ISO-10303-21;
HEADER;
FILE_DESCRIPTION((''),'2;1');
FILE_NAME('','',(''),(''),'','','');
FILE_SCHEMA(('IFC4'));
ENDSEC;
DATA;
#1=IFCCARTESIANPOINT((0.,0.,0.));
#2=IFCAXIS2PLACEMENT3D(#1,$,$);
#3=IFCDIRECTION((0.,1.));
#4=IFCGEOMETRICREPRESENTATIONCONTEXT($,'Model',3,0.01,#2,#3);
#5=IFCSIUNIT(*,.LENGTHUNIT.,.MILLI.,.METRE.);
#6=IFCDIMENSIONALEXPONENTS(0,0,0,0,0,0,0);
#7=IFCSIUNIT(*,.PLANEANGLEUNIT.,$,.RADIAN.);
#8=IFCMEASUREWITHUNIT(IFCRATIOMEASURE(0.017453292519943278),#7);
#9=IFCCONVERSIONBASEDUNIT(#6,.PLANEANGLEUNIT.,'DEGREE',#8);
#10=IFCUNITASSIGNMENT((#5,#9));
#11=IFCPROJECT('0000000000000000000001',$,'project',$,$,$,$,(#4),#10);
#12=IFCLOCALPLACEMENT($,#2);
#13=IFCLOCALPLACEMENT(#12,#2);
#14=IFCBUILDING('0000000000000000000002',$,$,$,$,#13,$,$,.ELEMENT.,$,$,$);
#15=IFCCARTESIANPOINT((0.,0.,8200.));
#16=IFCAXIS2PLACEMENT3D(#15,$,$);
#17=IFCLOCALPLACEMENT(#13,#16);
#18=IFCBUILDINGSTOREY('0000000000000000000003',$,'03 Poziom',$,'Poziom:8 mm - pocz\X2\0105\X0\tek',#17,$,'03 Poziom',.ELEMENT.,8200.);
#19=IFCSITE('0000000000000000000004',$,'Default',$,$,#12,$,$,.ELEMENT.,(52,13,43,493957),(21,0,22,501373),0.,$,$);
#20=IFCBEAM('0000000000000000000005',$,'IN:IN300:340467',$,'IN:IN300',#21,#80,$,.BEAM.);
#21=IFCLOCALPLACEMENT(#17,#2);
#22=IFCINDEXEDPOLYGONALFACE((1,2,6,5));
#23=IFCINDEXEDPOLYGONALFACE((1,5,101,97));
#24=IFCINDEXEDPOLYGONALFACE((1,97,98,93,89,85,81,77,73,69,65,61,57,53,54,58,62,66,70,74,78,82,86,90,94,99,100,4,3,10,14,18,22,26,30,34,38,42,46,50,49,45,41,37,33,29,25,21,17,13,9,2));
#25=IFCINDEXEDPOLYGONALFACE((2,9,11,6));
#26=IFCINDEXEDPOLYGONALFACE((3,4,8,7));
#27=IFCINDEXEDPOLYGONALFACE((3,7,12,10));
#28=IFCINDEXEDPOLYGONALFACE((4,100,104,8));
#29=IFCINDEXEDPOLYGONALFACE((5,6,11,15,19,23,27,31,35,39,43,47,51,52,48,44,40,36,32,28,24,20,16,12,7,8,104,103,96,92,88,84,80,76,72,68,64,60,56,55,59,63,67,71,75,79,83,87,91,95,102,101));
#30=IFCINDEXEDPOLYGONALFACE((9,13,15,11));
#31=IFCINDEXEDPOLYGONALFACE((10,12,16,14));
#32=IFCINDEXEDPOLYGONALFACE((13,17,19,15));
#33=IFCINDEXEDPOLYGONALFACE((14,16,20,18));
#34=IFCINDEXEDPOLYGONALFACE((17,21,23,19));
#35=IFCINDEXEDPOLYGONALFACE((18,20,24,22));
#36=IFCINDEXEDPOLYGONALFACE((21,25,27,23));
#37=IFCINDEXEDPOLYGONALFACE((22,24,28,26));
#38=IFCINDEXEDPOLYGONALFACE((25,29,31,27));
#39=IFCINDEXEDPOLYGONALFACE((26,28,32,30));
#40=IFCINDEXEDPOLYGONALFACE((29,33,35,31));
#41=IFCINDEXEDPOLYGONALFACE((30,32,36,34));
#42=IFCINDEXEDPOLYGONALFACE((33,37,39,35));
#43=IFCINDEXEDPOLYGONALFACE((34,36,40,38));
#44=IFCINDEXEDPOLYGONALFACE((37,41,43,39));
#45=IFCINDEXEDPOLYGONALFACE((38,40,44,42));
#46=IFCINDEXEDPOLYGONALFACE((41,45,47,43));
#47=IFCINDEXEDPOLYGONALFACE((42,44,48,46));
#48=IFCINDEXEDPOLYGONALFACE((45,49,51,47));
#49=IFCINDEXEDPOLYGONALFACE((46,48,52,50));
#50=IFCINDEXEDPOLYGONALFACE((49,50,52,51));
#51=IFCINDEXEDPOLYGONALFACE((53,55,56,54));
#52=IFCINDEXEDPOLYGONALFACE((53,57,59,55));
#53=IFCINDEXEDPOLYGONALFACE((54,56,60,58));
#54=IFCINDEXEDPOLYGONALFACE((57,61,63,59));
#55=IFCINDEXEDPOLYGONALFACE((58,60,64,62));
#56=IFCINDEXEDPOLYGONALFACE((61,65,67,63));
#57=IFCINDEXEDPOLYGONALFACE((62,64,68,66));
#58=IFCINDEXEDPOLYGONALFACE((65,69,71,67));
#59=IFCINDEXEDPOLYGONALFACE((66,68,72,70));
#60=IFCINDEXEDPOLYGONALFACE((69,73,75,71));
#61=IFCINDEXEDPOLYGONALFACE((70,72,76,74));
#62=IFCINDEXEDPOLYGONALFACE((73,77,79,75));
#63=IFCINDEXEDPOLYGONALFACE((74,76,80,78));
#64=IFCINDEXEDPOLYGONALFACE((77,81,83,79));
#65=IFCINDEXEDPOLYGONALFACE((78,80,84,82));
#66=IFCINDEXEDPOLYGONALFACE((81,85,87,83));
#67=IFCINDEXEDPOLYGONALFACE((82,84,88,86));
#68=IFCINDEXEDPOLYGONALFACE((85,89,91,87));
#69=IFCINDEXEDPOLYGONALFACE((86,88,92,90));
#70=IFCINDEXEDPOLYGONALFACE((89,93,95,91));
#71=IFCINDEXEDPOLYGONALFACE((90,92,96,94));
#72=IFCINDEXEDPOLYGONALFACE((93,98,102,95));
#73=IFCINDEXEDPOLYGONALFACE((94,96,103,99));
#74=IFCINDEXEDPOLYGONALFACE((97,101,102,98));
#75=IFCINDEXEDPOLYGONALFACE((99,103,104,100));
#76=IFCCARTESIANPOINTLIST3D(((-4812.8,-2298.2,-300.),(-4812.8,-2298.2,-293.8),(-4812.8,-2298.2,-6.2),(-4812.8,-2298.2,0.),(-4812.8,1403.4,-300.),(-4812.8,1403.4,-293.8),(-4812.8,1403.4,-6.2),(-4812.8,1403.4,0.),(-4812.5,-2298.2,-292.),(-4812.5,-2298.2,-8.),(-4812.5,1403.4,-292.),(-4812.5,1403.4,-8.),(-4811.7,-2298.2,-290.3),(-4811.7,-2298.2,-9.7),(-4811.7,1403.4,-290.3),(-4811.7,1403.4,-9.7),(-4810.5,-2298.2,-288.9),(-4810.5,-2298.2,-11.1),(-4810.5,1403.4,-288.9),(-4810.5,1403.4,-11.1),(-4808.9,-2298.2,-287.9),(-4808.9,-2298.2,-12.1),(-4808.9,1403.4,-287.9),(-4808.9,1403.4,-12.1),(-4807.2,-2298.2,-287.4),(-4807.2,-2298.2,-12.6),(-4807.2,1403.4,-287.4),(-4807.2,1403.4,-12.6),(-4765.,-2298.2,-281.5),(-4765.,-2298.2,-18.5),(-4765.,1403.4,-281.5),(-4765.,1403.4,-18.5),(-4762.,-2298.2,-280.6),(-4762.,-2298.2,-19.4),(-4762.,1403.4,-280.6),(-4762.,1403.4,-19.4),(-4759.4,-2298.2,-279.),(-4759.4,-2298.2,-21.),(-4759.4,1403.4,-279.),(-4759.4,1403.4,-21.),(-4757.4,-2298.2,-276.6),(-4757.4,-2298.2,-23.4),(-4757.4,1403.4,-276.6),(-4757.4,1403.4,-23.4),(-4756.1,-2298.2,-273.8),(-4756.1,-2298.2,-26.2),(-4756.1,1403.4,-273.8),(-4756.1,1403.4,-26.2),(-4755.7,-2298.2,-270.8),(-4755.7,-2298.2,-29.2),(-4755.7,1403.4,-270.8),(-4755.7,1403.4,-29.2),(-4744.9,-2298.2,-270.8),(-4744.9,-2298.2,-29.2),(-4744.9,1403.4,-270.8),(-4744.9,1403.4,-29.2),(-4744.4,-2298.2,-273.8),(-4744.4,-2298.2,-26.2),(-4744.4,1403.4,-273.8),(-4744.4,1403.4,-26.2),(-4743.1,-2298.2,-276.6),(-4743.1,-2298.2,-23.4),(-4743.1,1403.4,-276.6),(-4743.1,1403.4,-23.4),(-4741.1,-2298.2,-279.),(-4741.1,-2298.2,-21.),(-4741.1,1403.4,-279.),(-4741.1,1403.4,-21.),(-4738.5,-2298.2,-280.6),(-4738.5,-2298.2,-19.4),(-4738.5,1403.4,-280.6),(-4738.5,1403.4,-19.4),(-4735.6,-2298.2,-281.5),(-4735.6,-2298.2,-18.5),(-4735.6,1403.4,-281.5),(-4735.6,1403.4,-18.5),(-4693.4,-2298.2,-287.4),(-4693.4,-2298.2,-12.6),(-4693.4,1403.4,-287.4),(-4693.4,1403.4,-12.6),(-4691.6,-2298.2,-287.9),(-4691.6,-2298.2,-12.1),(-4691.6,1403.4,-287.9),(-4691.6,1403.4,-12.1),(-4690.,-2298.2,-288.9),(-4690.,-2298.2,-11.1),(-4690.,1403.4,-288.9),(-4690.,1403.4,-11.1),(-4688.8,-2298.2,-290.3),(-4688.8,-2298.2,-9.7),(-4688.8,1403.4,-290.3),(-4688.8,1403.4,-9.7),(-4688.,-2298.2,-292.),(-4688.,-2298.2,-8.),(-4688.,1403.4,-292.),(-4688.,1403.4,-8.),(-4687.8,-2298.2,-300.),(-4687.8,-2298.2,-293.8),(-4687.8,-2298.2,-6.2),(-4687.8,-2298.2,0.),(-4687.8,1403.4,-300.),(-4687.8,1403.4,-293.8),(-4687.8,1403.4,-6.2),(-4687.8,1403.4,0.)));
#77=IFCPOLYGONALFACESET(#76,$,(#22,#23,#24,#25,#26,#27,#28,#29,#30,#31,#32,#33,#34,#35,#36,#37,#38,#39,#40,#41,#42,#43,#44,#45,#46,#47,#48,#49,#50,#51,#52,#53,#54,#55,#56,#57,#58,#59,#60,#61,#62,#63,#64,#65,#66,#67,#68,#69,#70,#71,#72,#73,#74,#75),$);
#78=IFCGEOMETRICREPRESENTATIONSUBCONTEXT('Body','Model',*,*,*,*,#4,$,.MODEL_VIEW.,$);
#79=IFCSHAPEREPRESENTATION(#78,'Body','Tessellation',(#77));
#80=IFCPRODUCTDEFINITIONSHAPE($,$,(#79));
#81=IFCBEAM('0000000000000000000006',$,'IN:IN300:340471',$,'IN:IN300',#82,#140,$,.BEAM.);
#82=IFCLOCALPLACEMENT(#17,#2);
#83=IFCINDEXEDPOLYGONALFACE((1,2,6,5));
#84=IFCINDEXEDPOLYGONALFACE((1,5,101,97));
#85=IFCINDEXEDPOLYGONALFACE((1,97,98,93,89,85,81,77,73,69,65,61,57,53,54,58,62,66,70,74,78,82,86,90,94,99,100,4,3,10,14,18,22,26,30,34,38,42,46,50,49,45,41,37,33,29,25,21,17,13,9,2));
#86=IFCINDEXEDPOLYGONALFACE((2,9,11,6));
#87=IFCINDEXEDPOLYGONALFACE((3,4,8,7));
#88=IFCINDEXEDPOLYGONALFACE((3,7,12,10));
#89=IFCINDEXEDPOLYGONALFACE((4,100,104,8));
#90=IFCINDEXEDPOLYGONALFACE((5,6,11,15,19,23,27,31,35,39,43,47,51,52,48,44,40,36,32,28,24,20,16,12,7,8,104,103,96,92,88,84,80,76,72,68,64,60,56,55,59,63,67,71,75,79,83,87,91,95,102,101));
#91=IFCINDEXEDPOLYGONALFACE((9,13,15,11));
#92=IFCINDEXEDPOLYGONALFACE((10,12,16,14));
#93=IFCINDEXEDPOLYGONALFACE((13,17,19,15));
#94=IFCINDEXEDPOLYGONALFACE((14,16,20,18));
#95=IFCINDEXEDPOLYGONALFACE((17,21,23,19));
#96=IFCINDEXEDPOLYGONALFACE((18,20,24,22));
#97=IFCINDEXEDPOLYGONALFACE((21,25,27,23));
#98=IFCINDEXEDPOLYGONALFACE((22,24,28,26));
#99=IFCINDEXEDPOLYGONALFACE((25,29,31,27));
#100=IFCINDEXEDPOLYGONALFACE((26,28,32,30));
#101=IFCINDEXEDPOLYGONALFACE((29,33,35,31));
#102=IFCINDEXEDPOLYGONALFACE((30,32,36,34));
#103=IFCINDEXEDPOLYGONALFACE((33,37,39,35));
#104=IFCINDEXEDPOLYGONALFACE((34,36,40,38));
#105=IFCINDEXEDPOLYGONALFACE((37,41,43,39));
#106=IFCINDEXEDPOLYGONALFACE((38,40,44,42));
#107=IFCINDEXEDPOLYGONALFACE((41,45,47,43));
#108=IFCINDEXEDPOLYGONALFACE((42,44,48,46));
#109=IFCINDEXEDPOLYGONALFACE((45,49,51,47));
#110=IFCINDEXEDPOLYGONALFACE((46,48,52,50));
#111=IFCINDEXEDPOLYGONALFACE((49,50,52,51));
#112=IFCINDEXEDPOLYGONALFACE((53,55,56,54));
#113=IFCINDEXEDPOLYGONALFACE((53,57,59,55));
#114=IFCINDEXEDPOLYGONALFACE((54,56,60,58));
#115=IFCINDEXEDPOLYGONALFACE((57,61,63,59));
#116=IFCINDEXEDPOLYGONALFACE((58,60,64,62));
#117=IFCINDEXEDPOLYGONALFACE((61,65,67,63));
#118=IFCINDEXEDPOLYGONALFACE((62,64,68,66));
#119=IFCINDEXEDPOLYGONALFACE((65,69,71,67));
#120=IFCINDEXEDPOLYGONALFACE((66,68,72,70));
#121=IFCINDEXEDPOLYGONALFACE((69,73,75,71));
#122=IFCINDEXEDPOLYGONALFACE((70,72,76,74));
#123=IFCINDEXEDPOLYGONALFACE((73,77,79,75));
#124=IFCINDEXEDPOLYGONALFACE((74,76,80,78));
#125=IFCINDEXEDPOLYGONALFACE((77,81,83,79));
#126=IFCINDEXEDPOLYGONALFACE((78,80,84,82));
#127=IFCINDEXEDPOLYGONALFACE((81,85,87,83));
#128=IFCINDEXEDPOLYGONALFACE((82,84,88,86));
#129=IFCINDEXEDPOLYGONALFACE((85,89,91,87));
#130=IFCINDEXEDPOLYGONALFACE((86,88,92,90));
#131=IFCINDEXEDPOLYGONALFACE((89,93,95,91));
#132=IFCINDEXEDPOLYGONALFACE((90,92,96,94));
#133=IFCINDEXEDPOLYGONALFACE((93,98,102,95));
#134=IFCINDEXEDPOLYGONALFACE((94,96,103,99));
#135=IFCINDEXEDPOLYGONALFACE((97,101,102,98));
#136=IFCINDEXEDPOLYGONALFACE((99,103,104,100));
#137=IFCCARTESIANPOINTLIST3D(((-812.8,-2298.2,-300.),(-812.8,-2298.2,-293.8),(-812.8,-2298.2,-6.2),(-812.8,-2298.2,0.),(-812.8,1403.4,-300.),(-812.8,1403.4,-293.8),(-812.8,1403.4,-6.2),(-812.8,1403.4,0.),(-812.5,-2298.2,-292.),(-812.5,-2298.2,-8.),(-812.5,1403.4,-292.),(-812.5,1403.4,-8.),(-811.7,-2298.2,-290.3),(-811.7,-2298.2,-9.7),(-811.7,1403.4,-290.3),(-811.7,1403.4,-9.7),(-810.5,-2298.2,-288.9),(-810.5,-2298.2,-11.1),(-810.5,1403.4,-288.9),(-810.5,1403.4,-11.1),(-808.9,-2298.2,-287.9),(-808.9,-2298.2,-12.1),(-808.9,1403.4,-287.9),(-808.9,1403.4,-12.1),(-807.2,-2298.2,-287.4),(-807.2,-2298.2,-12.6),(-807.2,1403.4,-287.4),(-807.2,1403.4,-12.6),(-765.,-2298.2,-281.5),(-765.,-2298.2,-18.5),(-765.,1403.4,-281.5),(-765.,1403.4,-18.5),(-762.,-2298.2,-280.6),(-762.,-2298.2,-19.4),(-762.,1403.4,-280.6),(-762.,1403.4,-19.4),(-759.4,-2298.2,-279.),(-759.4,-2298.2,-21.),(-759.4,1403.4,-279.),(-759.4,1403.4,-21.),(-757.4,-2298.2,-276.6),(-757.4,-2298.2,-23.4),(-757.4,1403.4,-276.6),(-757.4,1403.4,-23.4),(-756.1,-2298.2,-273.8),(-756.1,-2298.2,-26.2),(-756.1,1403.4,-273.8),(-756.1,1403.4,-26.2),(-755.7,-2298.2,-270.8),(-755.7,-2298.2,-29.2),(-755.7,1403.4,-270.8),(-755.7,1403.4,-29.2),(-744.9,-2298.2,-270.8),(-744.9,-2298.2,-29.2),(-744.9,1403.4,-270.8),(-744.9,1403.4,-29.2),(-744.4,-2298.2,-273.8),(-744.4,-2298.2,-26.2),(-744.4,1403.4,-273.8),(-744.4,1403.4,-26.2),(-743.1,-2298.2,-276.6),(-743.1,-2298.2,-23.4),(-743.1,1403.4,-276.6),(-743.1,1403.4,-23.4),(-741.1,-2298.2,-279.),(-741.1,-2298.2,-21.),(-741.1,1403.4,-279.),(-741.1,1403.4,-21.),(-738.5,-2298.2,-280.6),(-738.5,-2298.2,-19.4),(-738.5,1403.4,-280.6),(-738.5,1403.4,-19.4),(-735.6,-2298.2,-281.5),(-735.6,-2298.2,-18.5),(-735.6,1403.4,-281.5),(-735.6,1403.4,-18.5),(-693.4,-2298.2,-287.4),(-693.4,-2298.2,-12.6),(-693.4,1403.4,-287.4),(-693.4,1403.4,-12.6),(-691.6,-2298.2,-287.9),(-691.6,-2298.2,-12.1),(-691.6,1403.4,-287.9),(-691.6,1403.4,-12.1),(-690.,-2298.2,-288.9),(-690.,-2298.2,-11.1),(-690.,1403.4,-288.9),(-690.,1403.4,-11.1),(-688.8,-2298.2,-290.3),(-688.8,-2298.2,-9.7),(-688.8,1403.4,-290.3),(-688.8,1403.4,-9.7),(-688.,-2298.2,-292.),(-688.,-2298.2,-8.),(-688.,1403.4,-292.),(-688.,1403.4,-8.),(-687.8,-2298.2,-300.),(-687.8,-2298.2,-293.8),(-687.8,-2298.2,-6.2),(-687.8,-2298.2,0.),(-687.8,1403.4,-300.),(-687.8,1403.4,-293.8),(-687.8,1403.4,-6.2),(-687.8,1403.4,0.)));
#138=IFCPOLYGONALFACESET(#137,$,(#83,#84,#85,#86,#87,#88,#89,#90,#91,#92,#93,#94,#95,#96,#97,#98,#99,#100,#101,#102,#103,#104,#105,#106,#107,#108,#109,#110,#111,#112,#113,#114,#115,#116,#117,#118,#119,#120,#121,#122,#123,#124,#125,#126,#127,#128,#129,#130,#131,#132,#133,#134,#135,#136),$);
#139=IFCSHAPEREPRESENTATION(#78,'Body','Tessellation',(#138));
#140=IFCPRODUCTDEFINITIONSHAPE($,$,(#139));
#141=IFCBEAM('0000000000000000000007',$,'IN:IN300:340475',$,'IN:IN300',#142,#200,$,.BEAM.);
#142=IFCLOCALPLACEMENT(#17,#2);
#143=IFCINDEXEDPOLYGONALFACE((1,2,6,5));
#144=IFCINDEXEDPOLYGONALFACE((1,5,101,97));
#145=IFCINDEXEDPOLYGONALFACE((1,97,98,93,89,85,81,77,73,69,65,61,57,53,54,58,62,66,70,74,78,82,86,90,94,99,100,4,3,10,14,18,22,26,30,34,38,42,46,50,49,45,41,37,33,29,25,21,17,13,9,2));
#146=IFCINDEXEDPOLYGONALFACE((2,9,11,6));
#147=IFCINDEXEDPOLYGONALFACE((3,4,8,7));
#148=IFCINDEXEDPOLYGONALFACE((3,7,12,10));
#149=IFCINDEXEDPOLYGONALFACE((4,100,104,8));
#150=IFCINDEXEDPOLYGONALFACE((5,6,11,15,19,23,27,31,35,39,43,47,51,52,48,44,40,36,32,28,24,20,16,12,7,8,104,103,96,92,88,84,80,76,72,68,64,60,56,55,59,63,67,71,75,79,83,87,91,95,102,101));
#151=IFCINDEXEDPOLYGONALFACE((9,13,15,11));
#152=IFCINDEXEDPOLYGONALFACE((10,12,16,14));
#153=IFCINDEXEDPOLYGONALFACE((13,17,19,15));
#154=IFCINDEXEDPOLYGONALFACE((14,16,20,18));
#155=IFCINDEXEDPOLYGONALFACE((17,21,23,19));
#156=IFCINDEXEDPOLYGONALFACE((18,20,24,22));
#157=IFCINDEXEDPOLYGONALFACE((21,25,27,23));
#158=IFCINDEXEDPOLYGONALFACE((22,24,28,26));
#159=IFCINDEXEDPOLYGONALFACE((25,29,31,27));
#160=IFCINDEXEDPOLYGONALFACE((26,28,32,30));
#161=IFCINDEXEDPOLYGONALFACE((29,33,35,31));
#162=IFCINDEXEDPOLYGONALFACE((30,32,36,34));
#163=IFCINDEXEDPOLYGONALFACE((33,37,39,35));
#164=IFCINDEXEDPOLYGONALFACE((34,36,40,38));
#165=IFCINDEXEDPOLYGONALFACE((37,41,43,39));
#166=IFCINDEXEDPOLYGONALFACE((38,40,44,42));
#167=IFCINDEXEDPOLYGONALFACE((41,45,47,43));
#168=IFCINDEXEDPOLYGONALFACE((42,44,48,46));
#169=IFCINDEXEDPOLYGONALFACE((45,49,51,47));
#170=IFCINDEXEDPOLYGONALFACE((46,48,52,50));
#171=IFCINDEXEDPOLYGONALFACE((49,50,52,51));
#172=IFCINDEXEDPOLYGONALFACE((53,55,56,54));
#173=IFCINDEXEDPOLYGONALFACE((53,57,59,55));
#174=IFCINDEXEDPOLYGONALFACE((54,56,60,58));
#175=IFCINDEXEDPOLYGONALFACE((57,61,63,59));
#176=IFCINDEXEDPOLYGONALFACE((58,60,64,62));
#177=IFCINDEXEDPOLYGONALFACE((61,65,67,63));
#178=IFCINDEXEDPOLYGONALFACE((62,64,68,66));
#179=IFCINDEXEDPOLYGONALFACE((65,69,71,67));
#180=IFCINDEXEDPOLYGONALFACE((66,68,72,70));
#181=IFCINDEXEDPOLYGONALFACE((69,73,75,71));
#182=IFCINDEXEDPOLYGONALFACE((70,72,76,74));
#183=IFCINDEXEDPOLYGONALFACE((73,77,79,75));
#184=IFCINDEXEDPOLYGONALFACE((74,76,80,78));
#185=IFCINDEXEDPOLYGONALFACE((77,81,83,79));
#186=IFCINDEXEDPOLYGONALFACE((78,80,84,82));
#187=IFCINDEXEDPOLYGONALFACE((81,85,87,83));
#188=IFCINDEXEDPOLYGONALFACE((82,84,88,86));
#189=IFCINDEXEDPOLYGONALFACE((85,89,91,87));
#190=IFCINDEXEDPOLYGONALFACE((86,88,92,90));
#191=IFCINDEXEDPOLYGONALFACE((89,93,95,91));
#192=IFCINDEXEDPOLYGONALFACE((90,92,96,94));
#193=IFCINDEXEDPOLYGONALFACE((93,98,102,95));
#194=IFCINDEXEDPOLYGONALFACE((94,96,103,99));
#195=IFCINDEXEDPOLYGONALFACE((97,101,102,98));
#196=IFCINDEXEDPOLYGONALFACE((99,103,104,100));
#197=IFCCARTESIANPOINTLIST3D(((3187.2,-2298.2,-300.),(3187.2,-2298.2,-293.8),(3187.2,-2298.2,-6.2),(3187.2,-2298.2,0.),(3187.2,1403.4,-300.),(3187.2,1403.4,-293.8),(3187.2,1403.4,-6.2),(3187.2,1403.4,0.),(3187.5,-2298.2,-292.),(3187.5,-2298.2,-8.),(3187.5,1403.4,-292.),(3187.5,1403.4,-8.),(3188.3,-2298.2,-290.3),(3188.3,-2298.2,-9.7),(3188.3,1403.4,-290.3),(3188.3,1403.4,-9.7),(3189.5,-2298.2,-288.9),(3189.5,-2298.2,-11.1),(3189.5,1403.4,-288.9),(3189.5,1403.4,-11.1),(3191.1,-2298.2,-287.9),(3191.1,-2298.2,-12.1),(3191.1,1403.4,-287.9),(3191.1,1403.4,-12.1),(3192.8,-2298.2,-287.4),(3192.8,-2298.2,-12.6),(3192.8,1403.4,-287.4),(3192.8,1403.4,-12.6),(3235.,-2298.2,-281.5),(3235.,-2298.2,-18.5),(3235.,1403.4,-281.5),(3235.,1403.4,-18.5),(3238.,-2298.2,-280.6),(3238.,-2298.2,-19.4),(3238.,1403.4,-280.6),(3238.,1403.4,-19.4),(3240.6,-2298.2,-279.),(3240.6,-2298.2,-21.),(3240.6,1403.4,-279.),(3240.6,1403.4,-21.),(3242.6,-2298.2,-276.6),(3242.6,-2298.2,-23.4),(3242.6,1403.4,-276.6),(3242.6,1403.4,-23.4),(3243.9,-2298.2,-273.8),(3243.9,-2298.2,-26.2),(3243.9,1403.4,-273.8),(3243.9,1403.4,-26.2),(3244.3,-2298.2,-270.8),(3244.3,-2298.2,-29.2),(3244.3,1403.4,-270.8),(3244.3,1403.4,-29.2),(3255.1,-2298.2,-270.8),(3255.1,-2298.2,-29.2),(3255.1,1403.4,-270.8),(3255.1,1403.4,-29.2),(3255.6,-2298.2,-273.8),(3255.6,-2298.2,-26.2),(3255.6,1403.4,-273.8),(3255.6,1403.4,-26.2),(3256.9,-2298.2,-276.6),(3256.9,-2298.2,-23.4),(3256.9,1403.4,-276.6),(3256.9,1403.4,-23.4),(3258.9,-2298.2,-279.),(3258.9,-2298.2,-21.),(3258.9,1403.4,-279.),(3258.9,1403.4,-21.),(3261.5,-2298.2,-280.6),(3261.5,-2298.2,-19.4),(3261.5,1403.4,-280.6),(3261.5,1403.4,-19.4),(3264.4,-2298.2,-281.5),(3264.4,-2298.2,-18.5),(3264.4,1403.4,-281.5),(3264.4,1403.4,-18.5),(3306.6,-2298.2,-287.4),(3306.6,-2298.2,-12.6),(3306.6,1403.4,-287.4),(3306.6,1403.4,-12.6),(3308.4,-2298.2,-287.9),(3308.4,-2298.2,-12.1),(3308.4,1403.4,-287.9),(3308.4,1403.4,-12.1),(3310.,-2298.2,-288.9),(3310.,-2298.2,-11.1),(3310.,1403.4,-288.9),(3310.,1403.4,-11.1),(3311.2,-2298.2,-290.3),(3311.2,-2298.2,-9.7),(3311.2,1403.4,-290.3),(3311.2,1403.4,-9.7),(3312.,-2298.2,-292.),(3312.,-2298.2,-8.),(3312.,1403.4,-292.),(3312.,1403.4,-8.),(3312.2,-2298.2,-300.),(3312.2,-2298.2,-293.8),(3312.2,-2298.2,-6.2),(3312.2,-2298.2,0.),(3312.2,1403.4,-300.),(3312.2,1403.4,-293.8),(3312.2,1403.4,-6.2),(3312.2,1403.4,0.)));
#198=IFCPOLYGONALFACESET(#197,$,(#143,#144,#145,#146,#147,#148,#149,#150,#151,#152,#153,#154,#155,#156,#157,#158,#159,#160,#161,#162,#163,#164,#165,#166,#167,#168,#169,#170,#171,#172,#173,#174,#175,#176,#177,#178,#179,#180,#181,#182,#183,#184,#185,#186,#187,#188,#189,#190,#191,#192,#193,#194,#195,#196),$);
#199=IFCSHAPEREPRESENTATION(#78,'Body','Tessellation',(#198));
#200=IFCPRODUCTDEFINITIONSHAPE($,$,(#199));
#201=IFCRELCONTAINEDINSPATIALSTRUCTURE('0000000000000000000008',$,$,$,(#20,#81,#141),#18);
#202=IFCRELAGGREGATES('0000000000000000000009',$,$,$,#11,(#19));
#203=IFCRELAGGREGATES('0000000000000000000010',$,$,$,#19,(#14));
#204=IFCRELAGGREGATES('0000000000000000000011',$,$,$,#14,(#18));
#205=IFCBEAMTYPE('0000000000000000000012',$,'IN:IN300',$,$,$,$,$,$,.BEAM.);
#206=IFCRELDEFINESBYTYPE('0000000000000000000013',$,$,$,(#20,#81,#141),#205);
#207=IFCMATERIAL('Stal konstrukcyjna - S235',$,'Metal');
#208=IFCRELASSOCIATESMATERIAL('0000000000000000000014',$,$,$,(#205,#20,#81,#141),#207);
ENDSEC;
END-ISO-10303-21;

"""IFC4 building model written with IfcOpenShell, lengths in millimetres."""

from ifc_helpers import new_model, entity, si_unit, converted_unit, direction, frame, origin, place, context, subcontext, project, spatial, line, arc, indexed_curve, outline, extrude, source, transform, mapped, material, type_object, type_shapes, element, save


model = new_model("IFC4")

# Units and contexts
model_context = context("Model", 3, precision=0.01, world=origin(), true_north=direction((0.0, 1.0)))
body_context = subcontext(model_context, "Body", "Model", "MODEL_VIEW")
ifc_project = project(units=[si_unit("LENGTHUNIT", "METRE", prefix="MILLI"), converted_unit("PLANEANGLEUNIT", "DEGREE", entity("IfcRatioMeasure", 0.017453292519943278), si_unit("PLANEANGLEUNIT", "RADIAN"), dimensions=[0, 0, 0, 0, 0, 0, 0])], contexts=[model_context])

# Site, building, storey
site_placement = place(None, origin())
site = spatial("IfcSite", under=ifc_project, at=site_placement, Name="Default", CompositionType="ELEMENT", RefLatitude=(52, 13, 43, 493957), RefLongitude=(21, 0, 22, 501373), RefElevation=0.0)
building_placement = place(site_placement, origin())
building = spatial("IfcBuilding", under=site, at=building_placement, CompositionType="ELEMENT")
storey_placement = place(building_placement, frame((0.0, 0.0, 8200.0)))
storey = spatial("IfcBuildingStorey", under=building, at=storey_placement, Name="03 Poziom", ObjectType="Poziom:8 mm - początek", LongName="03 Poziom", CompositionType="ELEMENT", Elevation=8200.0)

# Shared definitions
ifc_material_1 = material(Name="Stal konstrukcyjna - S235", Category="Metal")

# Beams
beam_type_1 = type_object("IfcBeamType", Name="IN:IN300", PredefinedType="BEAM", material=ifc_material_1)
shared_shape_1 = source(origin(), body_context, "Body", "SweptSolid", [
    extrude(outline(indexed_curve([(143.8, -62.5), (150.0, -62.5), (150.0, 62.5), (143.8, 62.5), (139.6, 60.9), (137.4, 56.9), (131.5, 14.7), (127.9, 8.1), (120.8, 5.4), (-120.8, 5.4), (-127.9, 8.1), (-131.5, 14.7), (-137.4, 56.9), (-139.6, 60.9), (-143.8, 62.5), (-150.0, 62.5), (-150.0, -62.5), (-143.8, -62.5), (-139.6, -60.9), (-137.4, -56.9), (-131.5, -14.7), (-127.9, -8.1), (-120.8, -5.4), (120.8, -5.4), (127.9, -8.1), (131.5, -14.7), (137.4, -56.9), (139.6, -60.9)], segments=[line(1, 2, 3, 4), arc(4, 5, 6), line(6, 7), arc(7, 8, 9), line(9, 10), arc(10, 11, 12), line(12, 13), arc(13, 14, 15), line(15, 16, 17, 18), arc(18, 19, 20), line(20, 21), arc(21, 22, 23), line(23, 24), arc(24, 25, 26), line(26, 27), arc(27, 28, 1)], self_intersect=False)), frame((-1850.8, 0.0, 0.0), z_axis=(1.0, 0.0, 0.0), x_axis=(0.0, 0.0, -1.0)), (0.0, 0.0, 1.0), 3701.6),
])
type_shapes(beam_type_1, [shared_shape_1])
for number, where, z_axis, x_axis, name in (
    (1, (-4750.3, -447.4, -150.0), (0.0, 0.0, 1.0), (0.0, -1.0, 0.0), "IN:IN300:340467"),
    (2, (-750.3, -447.4, -150.0), (0.0, 0.0, 1.0), (0.0, -1.0, 0.0), "IN:IN300:340471"),
    (3, (3249.7, -447.4, -150.0), (0.0, 0.0, 1.0), (0.0, -1.0, 0.0), "IN:IN300:340475"),
):
    element("IfcBeam", number, at=place(storey_placement, frame(where, z_axis=z_axis, x_axis=x_axis)), inside=storey, type_object=beam_type_1, material=ifc_material_1, Name=name, ObjectType="IN:IN300", PredefinedType="BEAM", context=body_context, shape_type="MappedRepresentation", body=[
        mapped(shared_shape_1, transform((0.0, 0.0, 0.0), scale=1.0)),
    ])

save(model, "model.ifc")
